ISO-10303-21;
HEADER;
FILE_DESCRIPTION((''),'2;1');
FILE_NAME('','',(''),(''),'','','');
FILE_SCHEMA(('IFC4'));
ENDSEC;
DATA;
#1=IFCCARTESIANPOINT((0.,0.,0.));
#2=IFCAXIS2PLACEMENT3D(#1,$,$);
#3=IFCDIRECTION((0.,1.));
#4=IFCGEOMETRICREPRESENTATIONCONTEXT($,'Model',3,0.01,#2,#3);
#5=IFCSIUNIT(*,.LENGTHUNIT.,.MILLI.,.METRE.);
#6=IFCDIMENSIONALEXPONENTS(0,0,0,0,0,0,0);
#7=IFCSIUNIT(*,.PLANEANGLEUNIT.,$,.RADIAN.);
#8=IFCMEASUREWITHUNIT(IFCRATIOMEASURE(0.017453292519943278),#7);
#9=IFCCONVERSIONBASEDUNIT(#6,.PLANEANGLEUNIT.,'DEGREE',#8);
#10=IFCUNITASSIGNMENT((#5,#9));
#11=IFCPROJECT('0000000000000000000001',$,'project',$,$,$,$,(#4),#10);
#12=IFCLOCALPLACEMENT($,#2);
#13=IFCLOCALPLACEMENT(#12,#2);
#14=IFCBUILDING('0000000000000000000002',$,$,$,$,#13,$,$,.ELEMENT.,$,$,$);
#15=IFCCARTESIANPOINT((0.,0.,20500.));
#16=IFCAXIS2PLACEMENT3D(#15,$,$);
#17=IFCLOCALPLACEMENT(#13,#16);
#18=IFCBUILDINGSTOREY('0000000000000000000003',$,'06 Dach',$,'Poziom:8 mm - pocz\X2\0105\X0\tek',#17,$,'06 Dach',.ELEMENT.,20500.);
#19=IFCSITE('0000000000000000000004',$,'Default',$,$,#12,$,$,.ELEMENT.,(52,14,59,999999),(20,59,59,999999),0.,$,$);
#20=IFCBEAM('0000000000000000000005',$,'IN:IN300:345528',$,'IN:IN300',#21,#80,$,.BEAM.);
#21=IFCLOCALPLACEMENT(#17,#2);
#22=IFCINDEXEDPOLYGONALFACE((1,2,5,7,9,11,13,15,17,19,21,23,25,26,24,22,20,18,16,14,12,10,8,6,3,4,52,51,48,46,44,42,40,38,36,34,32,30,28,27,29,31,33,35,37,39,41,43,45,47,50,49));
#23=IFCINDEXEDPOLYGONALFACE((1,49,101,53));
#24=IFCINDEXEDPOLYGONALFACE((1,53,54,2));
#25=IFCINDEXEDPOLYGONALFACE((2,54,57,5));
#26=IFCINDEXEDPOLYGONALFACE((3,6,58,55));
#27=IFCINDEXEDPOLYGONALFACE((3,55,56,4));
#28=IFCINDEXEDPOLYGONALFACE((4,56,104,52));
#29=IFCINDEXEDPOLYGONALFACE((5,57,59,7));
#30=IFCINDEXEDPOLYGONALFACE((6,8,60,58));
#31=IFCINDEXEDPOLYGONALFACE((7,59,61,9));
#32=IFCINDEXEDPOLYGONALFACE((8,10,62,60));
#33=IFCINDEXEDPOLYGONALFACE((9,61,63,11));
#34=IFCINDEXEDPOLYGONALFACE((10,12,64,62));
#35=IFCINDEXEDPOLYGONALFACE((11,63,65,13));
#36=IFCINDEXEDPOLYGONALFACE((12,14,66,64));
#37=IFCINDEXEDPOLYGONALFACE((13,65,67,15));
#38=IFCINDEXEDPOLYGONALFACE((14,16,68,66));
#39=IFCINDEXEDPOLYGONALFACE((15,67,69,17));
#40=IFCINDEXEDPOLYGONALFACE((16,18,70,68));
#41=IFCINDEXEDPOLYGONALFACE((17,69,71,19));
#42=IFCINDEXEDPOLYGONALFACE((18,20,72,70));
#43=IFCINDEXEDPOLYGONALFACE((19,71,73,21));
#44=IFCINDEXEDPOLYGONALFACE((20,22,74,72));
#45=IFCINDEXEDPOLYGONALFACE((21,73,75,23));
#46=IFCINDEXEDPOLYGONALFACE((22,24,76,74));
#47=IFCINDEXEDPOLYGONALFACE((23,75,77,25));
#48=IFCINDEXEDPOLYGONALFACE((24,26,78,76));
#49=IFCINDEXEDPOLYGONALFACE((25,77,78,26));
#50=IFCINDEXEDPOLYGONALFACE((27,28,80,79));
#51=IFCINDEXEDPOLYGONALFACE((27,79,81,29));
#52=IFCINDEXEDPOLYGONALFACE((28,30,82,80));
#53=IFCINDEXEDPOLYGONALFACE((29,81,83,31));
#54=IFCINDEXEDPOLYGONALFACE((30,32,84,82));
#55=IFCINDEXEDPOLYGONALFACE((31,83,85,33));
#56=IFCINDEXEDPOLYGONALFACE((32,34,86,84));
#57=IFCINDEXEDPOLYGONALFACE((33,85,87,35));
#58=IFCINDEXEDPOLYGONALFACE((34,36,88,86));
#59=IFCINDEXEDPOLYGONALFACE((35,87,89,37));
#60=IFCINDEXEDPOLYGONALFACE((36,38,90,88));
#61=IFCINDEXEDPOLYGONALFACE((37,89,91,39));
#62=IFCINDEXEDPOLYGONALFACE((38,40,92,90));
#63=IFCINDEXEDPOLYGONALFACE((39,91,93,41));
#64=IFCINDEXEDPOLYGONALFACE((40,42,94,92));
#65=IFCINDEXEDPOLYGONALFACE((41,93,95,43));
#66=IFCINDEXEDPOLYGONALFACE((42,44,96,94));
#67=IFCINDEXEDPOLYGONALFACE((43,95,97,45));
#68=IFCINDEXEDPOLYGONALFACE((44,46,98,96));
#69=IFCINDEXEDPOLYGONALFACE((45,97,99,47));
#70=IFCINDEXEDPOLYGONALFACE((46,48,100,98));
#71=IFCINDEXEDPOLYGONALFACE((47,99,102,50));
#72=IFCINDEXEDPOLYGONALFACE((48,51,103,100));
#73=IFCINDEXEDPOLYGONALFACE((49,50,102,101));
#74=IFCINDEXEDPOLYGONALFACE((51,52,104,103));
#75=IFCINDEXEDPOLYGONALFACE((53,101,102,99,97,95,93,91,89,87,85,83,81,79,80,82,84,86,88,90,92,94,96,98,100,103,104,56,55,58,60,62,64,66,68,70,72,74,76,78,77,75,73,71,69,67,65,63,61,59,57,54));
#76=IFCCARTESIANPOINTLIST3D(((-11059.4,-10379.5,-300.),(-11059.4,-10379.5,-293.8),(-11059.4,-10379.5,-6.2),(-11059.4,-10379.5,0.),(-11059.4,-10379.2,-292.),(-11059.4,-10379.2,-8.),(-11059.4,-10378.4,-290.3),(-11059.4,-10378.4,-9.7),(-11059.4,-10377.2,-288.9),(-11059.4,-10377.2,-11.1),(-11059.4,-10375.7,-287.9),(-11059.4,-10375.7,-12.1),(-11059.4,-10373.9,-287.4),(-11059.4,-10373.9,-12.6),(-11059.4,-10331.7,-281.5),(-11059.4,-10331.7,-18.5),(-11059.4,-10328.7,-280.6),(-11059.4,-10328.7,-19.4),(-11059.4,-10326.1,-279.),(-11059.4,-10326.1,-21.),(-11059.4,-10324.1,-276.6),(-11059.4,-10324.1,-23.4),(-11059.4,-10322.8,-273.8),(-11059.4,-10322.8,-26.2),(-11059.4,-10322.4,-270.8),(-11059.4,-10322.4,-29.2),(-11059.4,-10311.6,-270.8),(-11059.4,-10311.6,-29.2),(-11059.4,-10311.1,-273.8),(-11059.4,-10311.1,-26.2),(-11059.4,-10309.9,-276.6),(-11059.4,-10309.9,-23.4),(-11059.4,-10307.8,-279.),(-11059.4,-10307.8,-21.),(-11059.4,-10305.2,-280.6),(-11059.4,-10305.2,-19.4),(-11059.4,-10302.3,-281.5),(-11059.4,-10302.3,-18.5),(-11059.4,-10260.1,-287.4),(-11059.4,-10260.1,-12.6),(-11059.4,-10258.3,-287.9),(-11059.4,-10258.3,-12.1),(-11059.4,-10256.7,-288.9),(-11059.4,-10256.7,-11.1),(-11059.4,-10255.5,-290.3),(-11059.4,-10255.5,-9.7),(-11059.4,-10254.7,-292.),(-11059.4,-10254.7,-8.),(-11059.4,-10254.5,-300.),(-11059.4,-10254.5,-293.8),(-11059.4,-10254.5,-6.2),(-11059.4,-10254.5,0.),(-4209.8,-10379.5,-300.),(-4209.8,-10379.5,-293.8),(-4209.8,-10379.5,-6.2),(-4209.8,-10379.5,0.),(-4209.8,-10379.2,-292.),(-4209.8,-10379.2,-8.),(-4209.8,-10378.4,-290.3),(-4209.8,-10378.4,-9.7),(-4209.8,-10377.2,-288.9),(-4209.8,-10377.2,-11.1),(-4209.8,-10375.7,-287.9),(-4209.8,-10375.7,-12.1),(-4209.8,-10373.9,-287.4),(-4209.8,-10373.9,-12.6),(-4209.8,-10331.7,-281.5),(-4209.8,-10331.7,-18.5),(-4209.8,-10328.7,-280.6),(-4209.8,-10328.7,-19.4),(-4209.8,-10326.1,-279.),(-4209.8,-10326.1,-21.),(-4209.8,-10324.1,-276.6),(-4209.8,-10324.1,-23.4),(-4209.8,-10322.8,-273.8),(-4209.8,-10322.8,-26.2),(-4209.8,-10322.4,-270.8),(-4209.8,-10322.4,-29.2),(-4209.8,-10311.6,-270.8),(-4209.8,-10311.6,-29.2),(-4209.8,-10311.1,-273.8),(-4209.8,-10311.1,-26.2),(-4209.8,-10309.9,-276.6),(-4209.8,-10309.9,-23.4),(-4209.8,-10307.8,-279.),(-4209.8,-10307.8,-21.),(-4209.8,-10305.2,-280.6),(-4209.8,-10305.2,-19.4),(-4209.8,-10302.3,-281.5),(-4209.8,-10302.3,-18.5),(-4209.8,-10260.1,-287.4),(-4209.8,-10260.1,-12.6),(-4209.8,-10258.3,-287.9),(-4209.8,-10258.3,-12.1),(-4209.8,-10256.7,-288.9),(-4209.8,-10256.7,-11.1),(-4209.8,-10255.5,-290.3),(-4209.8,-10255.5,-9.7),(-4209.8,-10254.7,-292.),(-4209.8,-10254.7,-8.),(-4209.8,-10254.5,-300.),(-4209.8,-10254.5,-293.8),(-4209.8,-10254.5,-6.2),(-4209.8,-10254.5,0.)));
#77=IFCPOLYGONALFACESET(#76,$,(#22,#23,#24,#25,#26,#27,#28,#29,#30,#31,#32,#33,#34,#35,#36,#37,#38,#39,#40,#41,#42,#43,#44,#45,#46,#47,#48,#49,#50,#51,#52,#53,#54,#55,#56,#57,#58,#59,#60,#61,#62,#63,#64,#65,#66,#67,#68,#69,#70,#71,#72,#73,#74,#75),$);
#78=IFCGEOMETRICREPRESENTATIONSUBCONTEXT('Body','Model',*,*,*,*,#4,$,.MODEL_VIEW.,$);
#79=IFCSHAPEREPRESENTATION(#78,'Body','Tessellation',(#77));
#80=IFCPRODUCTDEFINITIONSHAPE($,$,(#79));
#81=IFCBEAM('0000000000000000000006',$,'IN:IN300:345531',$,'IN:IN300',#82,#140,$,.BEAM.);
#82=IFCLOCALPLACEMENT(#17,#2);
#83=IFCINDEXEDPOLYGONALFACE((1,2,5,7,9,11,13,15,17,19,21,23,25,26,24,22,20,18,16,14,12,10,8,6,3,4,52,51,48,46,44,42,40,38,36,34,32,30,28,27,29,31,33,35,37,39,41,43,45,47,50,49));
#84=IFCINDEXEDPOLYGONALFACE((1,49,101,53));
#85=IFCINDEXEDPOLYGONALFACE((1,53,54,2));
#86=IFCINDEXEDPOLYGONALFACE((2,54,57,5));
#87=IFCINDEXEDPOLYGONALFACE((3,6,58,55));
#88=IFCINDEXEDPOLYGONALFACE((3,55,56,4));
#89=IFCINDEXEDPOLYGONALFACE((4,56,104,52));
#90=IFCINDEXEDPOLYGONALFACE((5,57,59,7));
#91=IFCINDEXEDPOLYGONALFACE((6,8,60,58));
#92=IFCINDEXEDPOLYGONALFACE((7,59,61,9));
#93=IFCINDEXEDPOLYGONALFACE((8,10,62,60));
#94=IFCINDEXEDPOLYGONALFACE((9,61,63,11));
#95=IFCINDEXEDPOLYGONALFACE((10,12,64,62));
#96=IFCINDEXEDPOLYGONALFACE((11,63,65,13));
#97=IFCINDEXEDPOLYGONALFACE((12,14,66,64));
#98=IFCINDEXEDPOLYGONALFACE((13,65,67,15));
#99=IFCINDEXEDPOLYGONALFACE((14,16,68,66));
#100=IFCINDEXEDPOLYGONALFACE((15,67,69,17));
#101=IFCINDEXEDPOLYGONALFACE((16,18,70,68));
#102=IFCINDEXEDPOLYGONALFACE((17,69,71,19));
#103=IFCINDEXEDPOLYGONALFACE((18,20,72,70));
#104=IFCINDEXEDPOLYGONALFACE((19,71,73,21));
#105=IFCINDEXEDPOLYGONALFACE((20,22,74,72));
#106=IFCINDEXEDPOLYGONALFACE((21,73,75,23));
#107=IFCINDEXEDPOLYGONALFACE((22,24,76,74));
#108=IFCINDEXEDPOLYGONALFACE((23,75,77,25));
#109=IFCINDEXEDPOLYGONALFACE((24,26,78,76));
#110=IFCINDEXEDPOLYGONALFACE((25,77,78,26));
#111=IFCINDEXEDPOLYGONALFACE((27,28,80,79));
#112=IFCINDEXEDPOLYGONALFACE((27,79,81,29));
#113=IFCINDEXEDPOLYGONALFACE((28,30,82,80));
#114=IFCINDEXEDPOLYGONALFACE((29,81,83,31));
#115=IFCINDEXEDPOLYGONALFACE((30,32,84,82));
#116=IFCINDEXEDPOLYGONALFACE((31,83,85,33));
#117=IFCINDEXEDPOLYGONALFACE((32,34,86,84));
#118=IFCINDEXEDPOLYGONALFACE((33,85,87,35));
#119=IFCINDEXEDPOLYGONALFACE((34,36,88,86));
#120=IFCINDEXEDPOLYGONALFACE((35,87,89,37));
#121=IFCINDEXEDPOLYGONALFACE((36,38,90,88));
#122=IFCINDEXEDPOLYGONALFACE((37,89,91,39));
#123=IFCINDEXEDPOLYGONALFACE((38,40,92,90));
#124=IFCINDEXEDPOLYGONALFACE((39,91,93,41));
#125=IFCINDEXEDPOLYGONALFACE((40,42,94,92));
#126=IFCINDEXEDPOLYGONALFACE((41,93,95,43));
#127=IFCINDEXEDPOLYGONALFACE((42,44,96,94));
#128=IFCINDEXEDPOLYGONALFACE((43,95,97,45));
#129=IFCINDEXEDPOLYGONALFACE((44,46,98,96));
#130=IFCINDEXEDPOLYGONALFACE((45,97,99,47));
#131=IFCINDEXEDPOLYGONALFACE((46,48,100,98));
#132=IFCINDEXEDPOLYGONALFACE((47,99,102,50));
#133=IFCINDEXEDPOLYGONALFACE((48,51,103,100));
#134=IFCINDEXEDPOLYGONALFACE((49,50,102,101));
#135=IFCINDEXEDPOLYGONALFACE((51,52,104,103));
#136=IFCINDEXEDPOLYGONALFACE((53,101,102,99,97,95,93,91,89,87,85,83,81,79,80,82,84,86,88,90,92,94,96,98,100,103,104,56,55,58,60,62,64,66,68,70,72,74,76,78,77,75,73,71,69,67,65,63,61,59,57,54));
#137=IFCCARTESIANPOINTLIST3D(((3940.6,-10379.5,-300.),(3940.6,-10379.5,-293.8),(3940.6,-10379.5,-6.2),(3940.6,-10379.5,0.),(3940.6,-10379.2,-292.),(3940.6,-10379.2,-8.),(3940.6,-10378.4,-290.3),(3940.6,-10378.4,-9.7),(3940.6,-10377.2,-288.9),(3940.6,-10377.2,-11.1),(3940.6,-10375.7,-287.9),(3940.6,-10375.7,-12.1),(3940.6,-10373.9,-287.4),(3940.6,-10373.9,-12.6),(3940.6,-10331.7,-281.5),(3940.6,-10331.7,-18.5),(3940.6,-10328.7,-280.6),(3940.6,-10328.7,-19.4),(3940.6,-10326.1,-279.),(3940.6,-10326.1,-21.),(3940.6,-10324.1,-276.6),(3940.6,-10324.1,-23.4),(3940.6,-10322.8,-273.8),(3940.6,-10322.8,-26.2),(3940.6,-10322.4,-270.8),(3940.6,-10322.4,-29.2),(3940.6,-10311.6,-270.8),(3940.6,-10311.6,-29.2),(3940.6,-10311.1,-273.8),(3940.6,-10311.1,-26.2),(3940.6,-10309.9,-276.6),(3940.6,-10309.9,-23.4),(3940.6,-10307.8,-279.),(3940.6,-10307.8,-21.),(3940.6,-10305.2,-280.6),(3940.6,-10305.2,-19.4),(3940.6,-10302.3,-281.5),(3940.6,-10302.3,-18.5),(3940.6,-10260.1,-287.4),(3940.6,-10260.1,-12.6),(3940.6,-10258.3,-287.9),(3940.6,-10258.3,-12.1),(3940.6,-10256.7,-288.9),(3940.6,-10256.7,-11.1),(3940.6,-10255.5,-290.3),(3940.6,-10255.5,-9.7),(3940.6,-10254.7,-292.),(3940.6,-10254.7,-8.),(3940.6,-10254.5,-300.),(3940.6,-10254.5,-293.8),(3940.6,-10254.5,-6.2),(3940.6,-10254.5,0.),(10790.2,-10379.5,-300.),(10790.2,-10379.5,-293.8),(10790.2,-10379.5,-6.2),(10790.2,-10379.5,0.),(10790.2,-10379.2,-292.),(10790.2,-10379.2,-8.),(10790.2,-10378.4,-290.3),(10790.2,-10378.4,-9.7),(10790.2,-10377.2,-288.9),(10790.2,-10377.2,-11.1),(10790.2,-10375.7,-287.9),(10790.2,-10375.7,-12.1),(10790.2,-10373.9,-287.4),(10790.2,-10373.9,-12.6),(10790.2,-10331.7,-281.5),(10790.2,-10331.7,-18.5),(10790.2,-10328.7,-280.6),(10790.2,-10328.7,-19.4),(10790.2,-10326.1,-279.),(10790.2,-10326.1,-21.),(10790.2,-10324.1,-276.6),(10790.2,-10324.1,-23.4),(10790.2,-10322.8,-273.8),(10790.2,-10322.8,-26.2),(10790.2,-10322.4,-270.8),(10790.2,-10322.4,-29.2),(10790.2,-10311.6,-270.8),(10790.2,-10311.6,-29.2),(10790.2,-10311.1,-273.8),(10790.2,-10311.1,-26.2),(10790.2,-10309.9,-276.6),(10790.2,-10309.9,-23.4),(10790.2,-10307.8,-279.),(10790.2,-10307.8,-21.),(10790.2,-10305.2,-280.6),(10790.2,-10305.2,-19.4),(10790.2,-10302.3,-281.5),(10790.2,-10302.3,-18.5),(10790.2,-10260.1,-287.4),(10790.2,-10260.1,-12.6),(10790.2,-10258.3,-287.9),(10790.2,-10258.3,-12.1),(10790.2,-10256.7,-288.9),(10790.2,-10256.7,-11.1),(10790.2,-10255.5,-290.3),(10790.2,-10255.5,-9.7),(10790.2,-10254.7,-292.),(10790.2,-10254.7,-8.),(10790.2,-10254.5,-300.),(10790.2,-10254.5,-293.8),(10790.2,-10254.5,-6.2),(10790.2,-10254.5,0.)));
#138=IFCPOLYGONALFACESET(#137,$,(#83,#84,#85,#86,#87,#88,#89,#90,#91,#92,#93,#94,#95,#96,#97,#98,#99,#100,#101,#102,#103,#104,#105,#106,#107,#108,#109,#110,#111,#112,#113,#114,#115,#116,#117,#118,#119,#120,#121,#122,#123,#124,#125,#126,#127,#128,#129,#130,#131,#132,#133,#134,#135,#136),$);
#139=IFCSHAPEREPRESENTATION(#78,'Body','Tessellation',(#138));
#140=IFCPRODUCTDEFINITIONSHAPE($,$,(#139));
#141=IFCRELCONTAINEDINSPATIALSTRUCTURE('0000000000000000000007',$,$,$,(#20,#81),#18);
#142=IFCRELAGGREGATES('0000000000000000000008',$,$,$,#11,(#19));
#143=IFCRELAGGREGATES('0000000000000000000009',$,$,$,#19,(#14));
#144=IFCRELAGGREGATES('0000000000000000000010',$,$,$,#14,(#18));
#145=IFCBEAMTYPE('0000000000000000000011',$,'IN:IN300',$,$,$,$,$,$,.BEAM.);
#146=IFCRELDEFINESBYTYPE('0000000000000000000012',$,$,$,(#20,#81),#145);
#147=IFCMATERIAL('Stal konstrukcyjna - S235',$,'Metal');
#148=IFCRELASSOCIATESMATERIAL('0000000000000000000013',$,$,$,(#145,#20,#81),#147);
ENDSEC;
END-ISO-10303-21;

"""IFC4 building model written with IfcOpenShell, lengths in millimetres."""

from ifc_helpers import new_model, entity, si_unit, converted_unit, direction, frame, origin, place, context, subcontext, project, spatial, line, arc, indexed_curve, outline, extrude, source, transform, mapped, material, type_object, type_shapes, element, save


model = new_model("IFC4")

# Units and contexts
model_context = context("Model", 3, precision=0.01, world=origin(), true_north=direction((0.0, 1.0)))
body_context = subcontext(model_context, "Body", "Model", "MODEL_VIEW")
ifc_project = project(units=[si_unit("LENGTHUNIT", "METRE", prefix="MILLI"), converted_unit("PLANEANGLEUNIT", "DEGREE", entity("IfcRatioMeasure", 0.017453292519943278), si_unit("PLANEANGLEUNIT", "RADIAN"), dimensions=[0, 0, 0, 0, 0, 0, 0])], contexts=[model_context])

# Site, building, storey
site_placement = place(None, origin())
site = spatial("IfcSite", under=ifc_project, at=site_placement, Name="Default", CompositionType="ELEMENT", RefLatitude=(52, 14, 59, 999999), RefLongitude=(20, 59, 59, 999999), RefElevation=0.0)
building_placement = place(site_placement, origin())
building = spatial("IfcBuilding", under=site, at=building_placement, CompositionType="ELEMENT")
storey_placement = place(building_placement, frame((0.0, 0.0, 20500.0)))
storey = spatial("IfcBuildingStorey", under=building, at=storey_placement, Name="06 Dach", ObjectType="Poziom:8 mm - początek", LongName="06 Dach", CompositionType="ELEMENT", Elevation=20500.0)

# Beams
ifc_material_1 = material(Name="Stal konstrukcyjna - S235", Category="Metal")
beam_type_1 = type_object("IfcBeamType", Name="IN:IN300", PredefinedType="BEAM", material=ifc_material_1)
shared_shape_1 = source(origin(), body_context, "Body", "SweptSolid", [
    extrude(outline(indexed_curve([(143.8, -62.5), (150.0, -62.5), (150.0, 62.5), (143.8, 62.5), (139.6, 60.9), (137.4, 56.9), (131.5, 14.7), (127.9, 8.1), (120.8, 5.4), (-120.8, 5.4), (-127.9, 8.1), (-131.5, 14.7), (-137.4, 56.9), (-139.6, 60.9), (-143.8, 62.5), (-150.0, 62.5), (-150.0, -62.5), (-143.8, -62.5), (-139.6, -60.9), (-137.4, -56.9), (-131.5, -14.7), (-127.9, -8.1), (-120.8, -5.4), (120.8, -5.4), (127.9, -8.1), (131.5, -14.7), (137.4, -56.9), (139.6, -60.9)], segments=[line(1, 2, 3, 4), arc(4, 5, 6), line(6, 7), arc(7, 8, 9), line(9, 10), arc(10, 11, 12), line(12, 13), arc(13, 14, 15), line(15, 16, 17, 18), arc(18, 19, 20), line(20, 21), arc(21, 22, 23), line(23, 24), arc(24, 25, 26), line(26, 27), arc(27, 28, 1)], self_intersect=False)), frame((-3424.8, 0.0, 0.0), z_axis=(1.0, 0.0, 0.0), x_axis=(0.0, 0.0, -1.0)), (0.0, 0.0, 1.0), 6849.6),
])
type_shapes(beam_type_1, [shared_shape_1])
for number, where, name in (
    (1, (-7634.6, -10317.0, -150.0), "IN:IN300:345528"),
    (2, (7365.4, -10317.0, -150.0), "IN:IN300:345531"),
):
    element("IfcBeam", number, at=place(storey_placement, frame(where)), inside=storey, type_object=beam_type_1, material=ifc_material_1, Name=name, ObjectType="IN:IN300", PredefinedType="BEAM", context=body_context, shape_type="MappedRepresentation", body=[
        mapped(shared_shape_1, transform((0.0, 0.0, 0.0), scale=1.0)),
    ])

save(model, "model.ifc")
